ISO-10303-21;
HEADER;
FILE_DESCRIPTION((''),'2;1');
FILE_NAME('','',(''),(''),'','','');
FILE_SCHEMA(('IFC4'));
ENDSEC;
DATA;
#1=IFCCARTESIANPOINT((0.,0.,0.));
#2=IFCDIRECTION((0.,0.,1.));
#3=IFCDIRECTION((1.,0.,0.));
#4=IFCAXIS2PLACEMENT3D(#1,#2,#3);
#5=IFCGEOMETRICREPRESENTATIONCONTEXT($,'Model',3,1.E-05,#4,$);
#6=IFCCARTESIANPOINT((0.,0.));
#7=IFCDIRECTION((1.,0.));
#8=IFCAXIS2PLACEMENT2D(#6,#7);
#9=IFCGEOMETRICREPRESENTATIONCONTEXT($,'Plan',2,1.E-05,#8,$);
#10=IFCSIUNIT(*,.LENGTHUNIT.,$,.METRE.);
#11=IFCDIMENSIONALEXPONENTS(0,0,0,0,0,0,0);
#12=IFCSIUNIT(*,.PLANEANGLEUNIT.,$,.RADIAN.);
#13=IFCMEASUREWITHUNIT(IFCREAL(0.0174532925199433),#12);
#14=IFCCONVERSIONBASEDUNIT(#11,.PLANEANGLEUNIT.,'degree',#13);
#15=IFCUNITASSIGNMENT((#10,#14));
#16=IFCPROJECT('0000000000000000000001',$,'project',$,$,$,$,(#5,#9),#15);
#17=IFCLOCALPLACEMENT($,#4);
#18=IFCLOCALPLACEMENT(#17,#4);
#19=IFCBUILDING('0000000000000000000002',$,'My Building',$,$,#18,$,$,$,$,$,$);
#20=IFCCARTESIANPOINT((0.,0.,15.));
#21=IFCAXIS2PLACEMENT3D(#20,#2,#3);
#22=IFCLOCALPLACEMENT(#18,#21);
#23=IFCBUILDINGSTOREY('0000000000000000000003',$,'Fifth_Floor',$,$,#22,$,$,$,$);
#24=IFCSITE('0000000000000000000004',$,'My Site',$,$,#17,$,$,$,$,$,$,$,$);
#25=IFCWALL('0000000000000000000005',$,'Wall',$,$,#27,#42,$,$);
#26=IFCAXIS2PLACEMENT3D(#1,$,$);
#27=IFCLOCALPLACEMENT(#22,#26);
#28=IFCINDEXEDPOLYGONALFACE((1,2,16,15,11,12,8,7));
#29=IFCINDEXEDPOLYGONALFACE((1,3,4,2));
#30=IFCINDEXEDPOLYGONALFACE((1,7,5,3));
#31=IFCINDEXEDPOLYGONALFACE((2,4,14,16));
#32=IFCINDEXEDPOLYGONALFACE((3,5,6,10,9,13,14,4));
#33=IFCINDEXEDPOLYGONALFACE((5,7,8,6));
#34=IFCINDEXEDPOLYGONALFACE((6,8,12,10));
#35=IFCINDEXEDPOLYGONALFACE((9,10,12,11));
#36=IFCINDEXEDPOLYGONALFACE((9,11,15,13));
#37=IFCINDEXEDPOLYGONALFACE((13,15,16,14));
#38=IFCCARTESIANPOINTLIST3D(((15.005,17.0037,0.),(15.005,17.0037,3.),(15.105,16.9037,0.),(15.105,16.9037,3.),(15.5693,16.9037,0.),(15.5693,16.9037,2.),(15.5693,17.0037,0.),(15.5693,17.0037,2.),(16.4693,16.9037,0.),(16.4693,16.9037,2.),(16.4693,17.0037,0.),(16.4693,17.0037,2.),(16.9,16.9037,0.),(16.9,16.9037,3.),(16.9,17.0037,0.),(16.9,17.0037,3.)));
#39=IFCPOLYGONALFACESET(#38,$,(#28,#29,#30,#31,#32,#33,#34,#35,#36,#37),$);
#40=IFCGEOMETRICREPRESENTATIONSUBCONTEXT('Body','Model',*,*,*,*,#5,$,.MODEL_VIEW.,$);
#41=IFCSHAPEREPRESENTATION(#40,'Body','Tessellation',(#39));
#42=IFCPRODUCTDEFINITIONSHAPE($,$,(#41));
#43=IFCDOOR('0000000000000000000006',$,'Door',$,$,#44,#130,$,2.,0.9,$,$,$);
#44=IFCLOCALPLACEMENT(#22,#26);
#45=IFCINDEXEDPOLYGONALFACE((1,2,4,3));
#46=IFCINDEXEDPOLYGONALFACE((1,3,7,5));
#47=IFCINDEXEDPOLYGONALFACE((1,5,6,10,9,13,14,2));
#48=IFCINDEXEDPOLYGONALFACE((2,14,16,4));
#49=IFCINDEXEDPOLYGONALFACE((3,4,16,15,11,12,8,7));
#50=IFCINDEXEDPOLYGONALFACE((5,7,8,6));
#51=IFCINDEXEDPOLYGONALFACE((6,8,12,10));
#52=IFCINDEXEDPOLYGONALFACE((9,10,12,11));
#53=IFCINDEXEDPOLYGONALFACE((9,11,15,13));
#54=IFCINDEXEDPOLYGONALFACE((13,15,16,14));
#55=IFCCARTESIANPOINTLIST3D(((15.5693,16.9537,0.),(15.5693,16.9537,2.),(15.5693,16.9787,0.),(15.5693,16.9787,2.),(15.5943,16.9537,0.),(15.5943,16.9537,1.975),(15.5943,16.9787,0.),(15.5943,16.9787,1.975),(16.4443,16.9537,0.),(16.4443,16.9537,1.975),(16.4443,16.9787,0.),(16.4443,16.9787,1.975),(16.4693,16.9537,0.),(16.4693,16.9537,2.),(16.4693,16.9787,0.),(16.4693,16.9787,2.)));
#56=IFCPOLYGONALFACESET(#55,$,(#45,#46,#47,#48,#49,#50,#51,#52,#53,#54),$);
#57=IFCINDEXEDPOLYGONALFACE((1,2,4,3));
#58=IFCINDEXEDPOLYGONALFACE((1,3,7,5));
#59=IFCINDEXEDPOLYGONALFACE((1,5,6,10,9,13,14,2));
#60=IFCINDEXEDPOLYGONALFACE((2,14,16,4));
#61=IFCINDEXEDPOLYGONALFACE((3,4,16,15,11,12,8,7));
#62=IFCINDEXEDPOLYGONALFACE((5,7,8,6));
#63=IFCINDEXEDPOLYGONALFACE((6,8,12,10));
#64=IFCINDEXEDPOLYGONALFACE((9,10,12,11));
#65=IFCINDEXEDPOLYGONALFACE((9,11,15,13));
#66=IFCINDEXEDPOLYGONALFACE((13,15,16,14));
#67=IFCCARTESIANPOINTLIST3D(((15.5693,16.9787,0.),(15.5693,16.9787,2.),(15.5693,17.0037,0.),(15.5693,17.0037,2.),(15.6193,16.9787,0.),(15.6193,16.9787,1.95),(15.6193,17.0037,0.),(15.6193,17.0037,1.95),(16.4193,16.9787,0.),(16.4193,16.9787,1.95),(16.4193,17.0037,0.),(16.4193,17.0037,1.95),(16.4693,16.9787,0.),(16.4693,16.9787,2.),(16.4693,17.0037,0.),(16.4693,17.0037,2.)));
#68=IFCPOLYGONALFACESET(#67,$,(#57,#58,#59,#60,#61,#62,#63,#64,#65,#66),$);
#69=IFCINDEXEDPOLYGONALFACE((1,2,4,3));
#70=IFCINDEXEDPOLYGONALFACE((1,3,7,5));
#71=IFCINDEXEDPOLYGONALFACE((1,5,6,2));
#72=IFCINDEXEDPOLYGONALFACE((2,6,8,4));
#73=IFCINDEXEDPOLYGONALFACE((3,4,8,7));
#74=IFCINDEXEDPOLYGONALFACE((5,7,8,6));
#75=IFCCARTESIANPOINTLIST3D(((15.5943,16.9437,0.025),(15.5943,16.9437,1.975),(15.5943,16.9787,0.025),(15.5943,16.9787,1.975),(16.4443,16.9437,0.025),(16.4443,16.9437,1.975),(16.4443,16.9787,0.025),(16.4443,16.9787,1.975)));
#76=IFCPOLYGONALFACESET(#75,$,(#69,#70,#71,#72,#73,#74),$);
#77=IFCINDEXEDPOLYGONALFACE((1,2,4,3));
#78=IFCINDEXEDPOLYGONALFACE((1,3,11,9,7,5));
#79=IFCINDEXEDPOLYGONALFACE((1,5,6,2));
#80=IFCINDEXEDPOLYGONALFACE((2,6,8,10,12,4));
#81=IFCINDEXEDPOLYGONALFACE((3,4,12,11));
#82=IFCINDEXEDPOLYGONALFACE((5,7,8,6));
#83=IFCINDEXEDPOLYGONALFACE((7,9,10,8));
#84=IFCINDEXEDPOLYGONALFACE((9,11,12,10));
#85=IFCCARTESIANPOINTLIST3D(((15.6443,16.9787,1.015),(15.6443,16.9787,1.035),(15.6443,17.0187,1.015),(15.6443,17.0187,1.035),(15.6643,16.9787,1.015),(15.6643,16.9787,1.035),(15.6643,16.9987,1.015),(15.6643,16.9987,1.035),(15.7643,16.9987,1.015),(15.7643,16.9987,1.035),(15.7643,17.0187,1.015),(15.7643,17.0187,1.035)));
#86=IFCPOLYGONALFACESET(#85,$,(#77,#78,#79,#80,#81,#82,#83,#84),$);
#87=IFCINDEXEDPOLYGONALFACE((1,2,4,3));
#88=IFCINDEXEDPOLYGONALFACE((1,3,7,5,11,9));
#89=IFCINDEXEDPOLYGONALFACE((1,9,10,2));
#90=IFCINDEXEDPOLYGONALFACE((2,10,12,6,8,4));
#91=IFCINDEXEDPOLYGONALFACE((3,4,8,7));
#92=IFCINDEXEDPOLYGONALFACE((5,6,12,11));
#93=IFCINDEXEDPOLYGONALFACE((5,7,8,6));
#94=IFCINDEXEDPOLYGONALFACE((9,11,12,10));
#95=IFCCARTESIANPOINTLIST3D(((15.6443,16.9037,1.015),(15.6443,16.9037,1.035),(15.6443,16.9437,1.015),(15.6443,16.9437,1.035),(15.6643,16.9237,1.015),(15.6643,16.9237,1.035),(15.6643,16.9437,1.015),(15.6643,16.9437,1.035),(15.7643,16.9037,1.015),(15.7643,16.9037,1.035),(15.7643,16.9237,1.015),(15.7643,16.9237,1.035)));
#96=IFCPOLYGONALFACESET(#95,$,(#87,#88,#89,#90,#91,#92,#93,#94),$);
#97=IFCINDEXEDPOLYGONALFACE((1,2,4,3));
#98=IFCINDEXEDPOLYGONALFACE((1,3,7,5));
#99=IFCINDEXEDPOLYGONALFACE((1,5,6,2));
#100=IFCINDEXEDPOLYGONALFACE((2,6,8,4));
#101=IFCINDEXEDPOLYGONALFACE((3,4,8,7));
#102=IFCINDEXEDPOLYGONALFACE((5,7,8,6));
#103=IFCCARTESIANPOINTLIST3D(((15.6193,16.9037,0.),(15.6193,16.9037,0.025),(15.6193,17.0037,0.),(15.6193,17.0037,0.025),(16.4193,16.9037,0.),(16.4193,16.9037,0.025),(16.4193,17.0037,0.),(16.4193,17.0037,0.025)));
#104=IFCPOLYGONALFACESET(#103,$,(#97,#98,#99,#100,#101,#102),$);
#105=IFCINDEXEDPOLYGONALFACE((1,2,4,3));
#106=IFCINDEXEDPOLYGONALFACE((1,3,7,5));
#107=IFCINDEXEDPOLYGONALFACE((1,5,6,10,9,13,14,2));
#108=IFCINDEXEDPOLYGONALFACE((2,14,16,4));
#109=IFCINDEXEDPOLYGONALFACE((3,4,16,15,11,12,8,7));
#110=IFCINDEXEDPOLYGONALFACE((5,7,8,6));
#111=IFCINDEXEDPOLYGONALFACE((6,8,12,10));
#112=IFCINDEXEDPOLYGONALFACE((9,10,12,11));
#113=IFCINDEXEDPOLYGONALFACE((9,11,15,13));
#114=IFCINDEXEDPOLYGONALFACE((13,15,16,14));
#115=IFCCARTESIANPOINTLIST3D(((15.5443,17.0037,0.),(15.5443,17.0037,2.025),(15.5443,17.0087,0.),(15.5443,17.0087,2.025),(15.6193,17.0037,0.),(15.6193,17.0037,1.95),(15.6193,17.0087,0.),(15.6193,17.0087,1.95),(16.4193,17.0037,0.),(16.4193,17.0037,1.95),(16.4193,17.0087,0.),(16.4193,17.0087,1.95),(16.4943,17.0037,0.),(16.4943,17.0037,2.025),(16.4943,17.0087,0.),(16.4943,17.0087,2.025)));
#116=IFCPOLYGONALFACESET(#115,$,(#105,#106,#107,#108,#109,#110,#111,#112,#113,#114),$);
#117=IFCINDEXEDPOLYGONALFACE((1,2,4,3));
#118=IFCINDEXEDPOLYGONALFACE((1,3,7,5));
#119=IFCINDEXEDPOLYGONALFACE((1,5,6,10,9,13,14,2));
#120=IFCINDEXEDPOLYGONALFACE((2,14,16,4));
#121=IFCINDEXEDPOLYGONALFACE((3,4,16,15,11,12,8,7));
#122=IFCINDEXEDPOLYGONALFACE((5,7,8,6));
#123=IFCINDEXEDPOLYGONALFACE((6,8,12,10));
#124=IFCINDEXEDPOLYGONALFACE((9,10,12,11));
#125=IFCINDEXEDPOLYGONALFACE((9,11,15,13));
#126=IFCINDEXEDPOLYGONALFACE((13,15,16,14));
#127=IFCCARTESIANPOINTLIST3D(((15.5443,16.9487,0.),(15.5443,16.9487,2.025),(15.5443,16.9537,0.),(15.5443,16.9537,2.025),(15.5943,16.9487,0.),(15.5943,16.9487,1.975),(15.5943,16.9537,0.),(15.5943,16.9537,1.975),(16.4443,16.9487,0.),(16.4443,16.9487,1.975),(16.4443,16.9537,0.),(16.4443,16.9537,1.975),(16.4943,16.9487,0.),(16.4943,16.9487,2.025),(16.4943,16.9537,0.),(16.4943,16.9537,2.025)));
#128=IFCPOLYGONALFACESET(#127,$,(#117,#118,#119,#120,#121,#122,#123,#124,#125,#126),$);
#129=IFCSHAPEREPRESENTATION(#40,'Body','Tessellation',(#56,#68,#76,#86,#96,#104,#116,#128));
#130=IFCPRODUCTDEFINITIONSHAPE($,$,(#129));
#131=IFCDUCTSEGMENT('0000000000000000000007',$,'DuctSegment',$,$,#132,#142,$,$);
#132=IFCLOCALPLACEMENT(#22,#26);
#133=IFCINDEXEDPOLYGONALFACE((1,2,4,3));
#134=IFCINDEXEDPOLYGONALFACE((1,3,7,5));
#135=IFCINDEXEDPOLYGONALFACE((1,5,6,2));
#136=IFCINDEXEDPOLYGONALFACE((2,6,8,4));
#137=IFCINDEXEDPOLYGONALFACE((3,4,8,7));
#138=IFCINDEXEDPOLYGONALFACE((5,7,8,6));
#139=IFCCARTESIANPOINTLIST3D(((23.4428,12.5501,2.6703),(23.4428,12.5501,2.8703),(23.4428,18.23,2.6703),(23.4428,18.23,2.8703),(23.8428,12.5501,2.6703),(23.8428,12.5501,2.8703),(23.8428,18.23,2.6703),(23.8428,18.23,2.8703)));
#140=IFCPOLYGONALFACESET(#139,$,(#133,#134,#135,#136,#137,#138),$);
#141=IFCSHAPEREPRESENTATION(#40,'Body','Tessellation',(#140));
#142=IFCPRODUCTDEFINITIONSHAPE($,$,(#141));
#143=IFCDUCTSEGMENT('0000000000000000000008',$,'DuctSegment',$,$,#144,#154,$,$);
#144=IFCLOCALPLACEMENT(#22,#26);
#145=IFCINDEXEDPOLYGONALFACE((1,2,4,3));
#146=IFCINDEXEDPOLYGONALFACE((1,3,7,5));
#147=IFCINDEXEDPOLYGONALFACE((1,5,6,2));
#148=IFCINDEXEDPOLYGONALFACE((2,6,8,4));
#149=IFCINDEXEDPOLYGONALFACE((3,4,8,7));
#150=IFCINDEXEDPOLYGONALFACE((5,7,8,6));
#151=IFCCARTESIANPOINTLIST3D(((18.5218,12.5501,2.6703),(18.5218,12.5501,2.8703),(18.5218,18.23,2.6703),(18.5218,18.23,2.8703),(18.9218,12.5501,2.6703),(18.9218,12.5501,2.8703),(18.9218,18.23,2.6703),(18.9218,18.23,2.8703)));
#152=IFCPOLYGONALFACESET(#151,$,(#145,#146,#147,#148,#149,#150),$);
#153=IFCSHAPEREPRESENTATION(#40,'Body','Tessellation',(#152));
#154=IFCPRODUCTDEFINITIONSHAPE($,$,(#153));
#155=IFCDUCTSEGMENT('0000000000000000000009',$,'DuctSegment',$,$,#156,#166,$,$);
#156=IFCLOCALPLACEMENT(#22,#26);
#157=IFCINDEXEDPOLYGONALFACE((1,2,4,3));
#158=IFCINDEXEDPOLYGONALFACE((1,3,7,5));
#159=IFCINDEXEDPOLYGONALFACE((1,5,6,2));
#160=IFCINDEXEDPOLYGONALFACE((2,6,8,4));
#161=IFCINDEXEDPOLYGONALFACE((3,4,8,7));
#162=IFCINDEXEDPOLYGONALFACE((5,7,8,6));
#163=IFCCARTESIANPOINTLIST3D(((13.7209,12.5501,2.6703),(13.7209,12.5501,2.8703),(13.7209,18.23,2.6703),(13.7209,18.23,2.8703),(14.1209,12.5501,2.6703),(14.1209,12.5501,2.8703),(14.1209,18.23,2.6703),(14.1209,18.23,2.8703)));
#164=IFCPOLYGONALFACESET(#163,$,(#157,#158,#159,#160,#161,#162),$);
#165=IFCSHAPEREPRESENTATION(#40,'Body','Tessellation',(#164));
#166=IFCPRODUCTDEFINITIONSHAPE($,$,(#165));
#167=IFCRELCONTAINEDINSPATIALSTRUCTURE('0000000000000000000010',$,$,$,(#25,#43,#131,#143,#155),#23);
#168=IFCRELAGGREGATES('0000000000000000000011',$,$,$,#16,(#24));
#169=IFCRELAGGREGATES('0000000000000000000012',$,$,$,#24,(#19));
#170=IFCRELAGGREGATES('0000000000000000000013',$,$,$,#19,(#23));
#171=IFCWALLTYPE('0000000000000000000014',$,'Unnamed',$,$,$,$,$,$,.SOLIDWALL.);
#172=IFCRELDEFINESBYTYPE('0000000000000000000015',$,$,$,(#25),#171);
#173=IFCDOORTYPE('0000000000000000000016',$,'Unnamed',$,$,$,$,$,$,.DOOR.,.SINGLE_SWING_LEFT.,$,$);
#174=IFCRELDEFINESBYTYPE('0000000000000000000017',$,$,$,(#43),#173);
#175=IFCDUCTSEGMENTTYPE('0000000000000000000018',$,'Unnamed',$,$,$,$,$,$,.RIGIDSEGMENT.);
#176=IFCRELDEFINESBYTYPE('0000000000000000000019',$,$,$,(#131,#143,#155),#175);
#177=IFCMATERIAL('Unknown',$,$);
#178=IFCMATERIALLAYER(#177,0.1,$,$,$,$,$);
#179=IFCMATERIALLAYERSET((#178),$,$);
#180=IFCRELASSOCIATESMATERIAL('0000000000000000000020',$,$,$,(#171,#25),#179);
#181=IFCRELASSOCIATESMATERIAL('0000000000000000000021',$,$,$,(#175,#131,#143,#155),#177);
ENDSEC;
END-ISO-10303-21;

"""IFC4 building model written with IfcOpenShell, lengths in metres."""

from ifc_helpers import new_model, entity, si_unit, converted_unit, frame, origin_with_axes, origin_2d_with_axis, place, context, subcontext, project, spatial, line, indexed_curve, rectangle, outline, extrude, shape, source, transform, mapped, material, layer, layer_set, layer_usage, material_profile, profile_set, profile_usage, type_object, type_shapes, element, fill, save


model = new_model("IFC4")

# Units and contexts
model_context = context("Model", 3, precision=1e-05, world=origin_with_axes())
plan_context = context("Plan", 2, precision=1e-05, world=origin_2d_with_axis())
body_context_1 = subcontext(model_context, "Body", "Model", "MODEL_VIEW")
body_context_2 = subcontext(plan_context, "Body", "Plan", "PLAN_VIEW")
ifc_project = project(units=[si_unit("LENGTHUNIT", "METRE"), converted_unit("PLANEANGLEUNIT", "degree", entity("IfcReal", 0.0174532925199433), si_unit("PLANEANGLEUNIT", "RADIAN"), dimensions=[0, 0, 0, 0, 0, 0, 0])], contexts=[model_context, plan_context])

# Site, building, storey
site_placement = place(None, origin_with_axes())
site = spatial("IfcSite", under=ifc_project, at=site_placement, Name="My Site")
building_placement = place(site_placement, origin_with_axes())
building = spatial("IfcBuilding", under=site, at=building_placement, Name="My Building")
storey_placement = place(building_placement, frame((0.0, 0.0, 15.0), z_axis=(0.0, 0.0, 1.0), x_axis=(1.0, 0.0, 0.0)))
storey = spatial("IfcBuildingStorey", under=building, at=storey_placement, Name="Fifth_Floor")

# Shared definitions
ifc_material = material(Name="Unknown")
ifc_layer = layer(ifc_material, 0.1)
ifc_layer_set = layer_set([ifc_layer])
wall_type = type_object("IfcWallType", Name="Unnamed", PredefinedType="SOLIDWALL", material=ifc_layer_set)

# Wall, opening, door
shared_shape_1 = source(origin_with_axes(), body_context_1, "Body", "SweptSolid", [
    extrude(outline(indexed_curve([(0.0, 0.0), (0.9, 0.0), (0.9, 2.0), (0.0, 2.0)], segments=[line(1, 2, 3, 4, 1)])), frame((0.0, -0.6, 0.0), z_axis=(0.0, -1.0, 0.0), x_axis=(1.0, 0.0, 0.0)), (0.0, 0.0, -1.0), 1.2),
])
door_type = type_object("IfcDoorType", Name="Unnamed", OperationType="SINGLE_SWING_LEFT", PredefinedType="DOOR")
shared_shape_2 = source(origin_with_axes(), body_context_1, "Body", "SweptSolid", [
    extrude(outline(indexed_curve([(0.0, 0.0), (0.0, 2.0), (0.9, 2.0), (0.9, 0.0), (0.875, 0.0), (0.875, 1.975), (0.025, 1.975), (0.025, 0.0)], segments=[line(1, 2, 3, 4, 5, 6, 7, 8, 1)])), frame((0.0, 0.025, 0.0), z_axis=(0.0, -1.0, 0.0), x_axis=(1.0, 0.0, 0.0)), (0.0, 0.0, -1.0), 0.025),
    extrude(outline(indexed_curve([(0.0, 0.0), (0.0, 2.0), (0.9, 2.0), (0.9, 0.0), (0.85, 0.0), (0.85, 1.95), (0.05, 1.95), (0.05, 0.0)], segments=[line(1, 2, 3, 4, 5, 6, 7, 8, 1)])), frame((0.0, 0.0, 0.0), z_axis=(0.0, -1.0, 0.0), x_axis=(1.0, 0.0, 0.0)), (0.0, 0.0, -1.0), 0.025),
    extrude(outline(indexed_curve([(0.0, 0.0), (0.85, 0.0), (0.85, 0.035), (0.0, 0.035)], segments=[line(1, 2, 3, 4, 1)])), frame((0.025, 0.025, 0.025), z_axis=(0.0, 0.0, 1.0), x_axis=(1.0, 0.0, 0.0)), (0.0, 0.0, 1.0), 1.95),
    extrude(outline(indexed_curve([(0.0, 0.0), (0.0, -0.04), (-0.12, -0.04), (-0.12, -0.02), (-0.02, -0.02), (-0.02, 0.0)], segments=[line(1, 2, 3, 4, 5, 6, 1)])), frame((0.825, 0.025, 1.015), z_axis=(0.0, 0.0, 1.0), x_axis=(1.0, 0.0, 0.0)), (0.0, 0.0, 1.0), 0.02),
    extrude(outline(indexed_curve([(0.0, 0.0), (0.0, 0.04), (-0.12, 0.04), (-0.12, 0.02), (-0.02, 0.02), (-0.02, 0.0)], segments=[line(1, 2, 3, 4, 5, 6, 1)])), frame((0.825, 0.06, 1.015), z_axis=(0.0, 0.0, 1.0), x_axis=(1.0, 0.0, 0.0)), (0.0, 0.0, 1.0), 0.02),
    extrude(outline(indexed_curve([(0.0, 0.0), (0.8, 0.0), (0.8, 0.1), (0.0, 0.1)], segments=[line(1, 2, 3, 4, 1)])), frame((0.05, 0.0, 0.0), z_axis=(0.0, 0.0, 1.0), x_axis=(1.0, 0.0, 0.0)), (0.0, 0.0, 1.0), 0.025),
    extrude(outline(indexed_curve([(0.0, 0.0), (0.0, 2.025), (0.95, 2.025), (0.95, 0.0), (0.875, 0.0), (0.875, 1.95), (0.075, 1.95), (0.075, 0.0)], segments=[line(1, 2, 3, 4, 5, 6, 7, 8, 1)])), frame((-0.025, -0.005, 0.0), z_axis=(0.0, -1.0, 0.0), x_axis=(1.0, 0.0, 0.0)), (0.0, 0.0, -1.0), 0.005),
    extrude(outline(indexed_curve([(0.0, 0.0), (0.0, 2.025), (0.95, 2.025), (0.95, 0.0), (0.9, 0.0), (0.9, 1.975), (0.05, 1.975), (0.05, 0.0)], segments=[line(1, 2, 3, 4, 5, 6, 7, 8, 1)])), frame((-0.025, 0.05, 0.0), z_axis=(0.0, -1.0, 0.0), x_axis=(1.0, 0.0, 0.0)), (0.0, 0.0, -1.0), 0.005),
])
shared_shape_3 = source(origin_with_axes(), body_context_2, "Body", "Curve2D", [
    entity("IfcIndexedPolyCurve", entity("IfcCartesianPointList2D", [[0.0, 0.0], [0.0, 0.05], [0.025, 0.05], [0.025, 0.025], [0.05, 0.025], [0.05, 0.0]]), [entity("IfcLineIndex", [1, 2, 3, 4, 5, 6, 1])]),
    entity("IfcIndexedPolyCurve", entity("IfcCartesianPointList2D", [[0.9, 0.0], [0.9, 0.05], [0.875, 0.05], [0.875, 0.025], [0.85, 0.025], [0.85, 0.0]]), [entity("IfcLineIndex", [1, 2, 3, 4, 5, 6, 1])]),
    entity("IfcTrimmedCurve", entity("IfcEllipse", entity("IfcAxis2Placement2D", entity("IfcCartesianPoint", [0.06, 0.05]), entity("IfcDirection", [1.0, 0.0])), 0.815, 0.85), [entity("IfcCartesianPoint", [0.875, 0.05])], [entity("IfcCartesianPoint", [0.06, 0.9])], True, "CARTESIAN"),
    entity("IfcIndexedPolyCurve", entity("IfcCartesianPointList2D", [[0.025, 0.05], [0.06, 0.05], [0.06, 0.9], [0.025, 0.9]]), [entity("IfcLineIndex", [1, 2, 3, 4, 1])]),
])
type_shapes(door_type, [shared_shape_2, shared_shape_3])
ifc_layer_usage_1 = layer_usage(ifc_layer_set, "AXIS2", "POSITIVE", 0.0)
wall_1_placement = place(storey_placement, frame((16.9, 17.0037, 0.0), z_axis=(0.0, 0.0, 1.0), x_axis=(-1.0, 0.0, 0.0)))
wall_1 = element("IfcWall", 1, at=wall_1_placement, inside=storey, type_object=wall_type, material=ifc_layer_usage_1, Name="Wall", context=body_context_1, shape_type="SweptSolid", body=[
    extrude(outline(indexed_curve([(0.0, 0.0), (0.0, 0.1), (1.795, 0.1), (1.895, 0.0)], segments=[line(1, 2, 3, 4, 1)])), origin_with_axes(), (0.0, 0.0, 1.0), 3.0),
])
opening_1_placement = place(wall_1_placement, frame((0.4307, 0.0, 0.0), z_axis=(0.0, 0.0, 1.0), x_axis=(1.0, 0.0, 0.0)))
opening_1 = element("IfcOpeningElement", 2, at=opening_1_placement, cuts=wall_1, PredefinedType="OPENING", context=body_context_1, shape_type="MappedRepresentation", body=[
    mapped(shared_shape_1, transform((0.0, 0.0, 0.0), x_axis=(1.0, 0.0, 0.0), y_axis=(0.0, 1.0, 0.0), z_axis=(0.0, 0.0, 1.0), scale=1.0)),
])
door_1_placement = place(opening_1_placement, frame((0.0, 0.0, 0.0), z_axis=(0.0, 0.0, 1.0), x_axis=(1.0, 0.0, 0.0)))
door_1 = element("IfcDoor", 3, at=door_1_placement, inside=storey, type_object=door_type, Name="Door", OverallHeight=2.0, OverallWidth=0.9, shapes=[
    shape(body_context_1, "Body", "MappedRepresentation", [mapped(shared_shape_2, transform((0.0, 0.0, 0.0), x_axis=(1.0, 0.0, 0.0), y_axis=(0.0, 1.0, 0.0), z_axis=(0.0, 0.0, 1.0), scale=1.0))]),
    shape(body_context_2, "Body", "MappedRepresentation", [mapped(shared_shape_3, transform((0.0, 0.0, 0.0), x_axis=(1.0, 0.0, 0.0), y_axis=(0.0, 1.0, 0.0), z_axis=(0.0, 0.0, 1.0), scale=1.0))]),
])
fill(opening_1, door_1)

# Duct segments
ifc_material_profile_1 = material_profile(ifc_material, rectangle(XDim=0.4, YDim=0.2))
ifc_profile_set_1 = profile_set([ifc_material_profile_1])
ifc_profile_usage_1 = profile_usage(ifc_profile_set_1, cardinal=5)
duct_segment_type = type_object("IfcDuctSegmentType", Name="Unnamed", PredefinedType="RIGIDSEGMENT", material=ifc_profile_set_1)
duct_segment_1_placement = place(storey_placement, frame((23.6428, 12.5501, 2.7703), z_axis=(0.0, 1.0, 0.0), x_axis=(-1.0, 0.0, 0.0)))
element("IfcDuctSegment", 4, at=duct_segment_1_placement, inside=storey, type_object=duct_segment_type, material=ifc_profile_usage_1, Name="DuctSegment", context=body_context_1, shape_type="SweptSolid", body=[
    extrude(rectangle(XDim=0.4, YDim=0.2), origin_with_axes(), (0.0, 0.0, 1.0), 5.6799),
])
ifc_profile_usage_2 = profile_usage(ifc_profile_set_1, cardinal=5)
duct_segment_2_placement = place(storey_placement, frame((18.7218, 12.5501, 2.7703), z_axis=(0.0, 1.0, 0.0), x_axis=(-1.0, 0.0, 0.0)))
element("IfcDuctSegment", 5, at=duct_segment_2_placement, inside=storey, type_object=duct_segment_type, material=ifc_profile_usage_2, Name="DuctSegment", context=body_context_1, shape_type="SweptSolid", body=[
    extrude(rectangle(XDim=0.4, YDim=0.2), origin_with_axes(), (0.0, 0.0, 1.0), 5.6799),
])
ifc_profile_usage_3 = profile_usage(ifc_profile_set_1, cardinal=5)
duct_segment_3_placement = place(storey_placement, frame((13.9209, 12.5501, 2.7703), z_axis=(0.0, 1.0, 0.0), x_axis=(-1.0, 0.0, 0.0)))
element("IfcDuctSegment", 6, at=duct_segment_3_placement, inside=storey, type_object=duct_segment_type, material=ifc_profile_usage_3, Name="DuctSegment", context=body_context_1, shape_type="SweptSolid", body=[
    extrude(rectangle(XDim=0.4, YDim=0.2), origin_with_axes(), (0.0, 0.0, 1.0), 5.6799),
])

save(model, "model.ifc")
